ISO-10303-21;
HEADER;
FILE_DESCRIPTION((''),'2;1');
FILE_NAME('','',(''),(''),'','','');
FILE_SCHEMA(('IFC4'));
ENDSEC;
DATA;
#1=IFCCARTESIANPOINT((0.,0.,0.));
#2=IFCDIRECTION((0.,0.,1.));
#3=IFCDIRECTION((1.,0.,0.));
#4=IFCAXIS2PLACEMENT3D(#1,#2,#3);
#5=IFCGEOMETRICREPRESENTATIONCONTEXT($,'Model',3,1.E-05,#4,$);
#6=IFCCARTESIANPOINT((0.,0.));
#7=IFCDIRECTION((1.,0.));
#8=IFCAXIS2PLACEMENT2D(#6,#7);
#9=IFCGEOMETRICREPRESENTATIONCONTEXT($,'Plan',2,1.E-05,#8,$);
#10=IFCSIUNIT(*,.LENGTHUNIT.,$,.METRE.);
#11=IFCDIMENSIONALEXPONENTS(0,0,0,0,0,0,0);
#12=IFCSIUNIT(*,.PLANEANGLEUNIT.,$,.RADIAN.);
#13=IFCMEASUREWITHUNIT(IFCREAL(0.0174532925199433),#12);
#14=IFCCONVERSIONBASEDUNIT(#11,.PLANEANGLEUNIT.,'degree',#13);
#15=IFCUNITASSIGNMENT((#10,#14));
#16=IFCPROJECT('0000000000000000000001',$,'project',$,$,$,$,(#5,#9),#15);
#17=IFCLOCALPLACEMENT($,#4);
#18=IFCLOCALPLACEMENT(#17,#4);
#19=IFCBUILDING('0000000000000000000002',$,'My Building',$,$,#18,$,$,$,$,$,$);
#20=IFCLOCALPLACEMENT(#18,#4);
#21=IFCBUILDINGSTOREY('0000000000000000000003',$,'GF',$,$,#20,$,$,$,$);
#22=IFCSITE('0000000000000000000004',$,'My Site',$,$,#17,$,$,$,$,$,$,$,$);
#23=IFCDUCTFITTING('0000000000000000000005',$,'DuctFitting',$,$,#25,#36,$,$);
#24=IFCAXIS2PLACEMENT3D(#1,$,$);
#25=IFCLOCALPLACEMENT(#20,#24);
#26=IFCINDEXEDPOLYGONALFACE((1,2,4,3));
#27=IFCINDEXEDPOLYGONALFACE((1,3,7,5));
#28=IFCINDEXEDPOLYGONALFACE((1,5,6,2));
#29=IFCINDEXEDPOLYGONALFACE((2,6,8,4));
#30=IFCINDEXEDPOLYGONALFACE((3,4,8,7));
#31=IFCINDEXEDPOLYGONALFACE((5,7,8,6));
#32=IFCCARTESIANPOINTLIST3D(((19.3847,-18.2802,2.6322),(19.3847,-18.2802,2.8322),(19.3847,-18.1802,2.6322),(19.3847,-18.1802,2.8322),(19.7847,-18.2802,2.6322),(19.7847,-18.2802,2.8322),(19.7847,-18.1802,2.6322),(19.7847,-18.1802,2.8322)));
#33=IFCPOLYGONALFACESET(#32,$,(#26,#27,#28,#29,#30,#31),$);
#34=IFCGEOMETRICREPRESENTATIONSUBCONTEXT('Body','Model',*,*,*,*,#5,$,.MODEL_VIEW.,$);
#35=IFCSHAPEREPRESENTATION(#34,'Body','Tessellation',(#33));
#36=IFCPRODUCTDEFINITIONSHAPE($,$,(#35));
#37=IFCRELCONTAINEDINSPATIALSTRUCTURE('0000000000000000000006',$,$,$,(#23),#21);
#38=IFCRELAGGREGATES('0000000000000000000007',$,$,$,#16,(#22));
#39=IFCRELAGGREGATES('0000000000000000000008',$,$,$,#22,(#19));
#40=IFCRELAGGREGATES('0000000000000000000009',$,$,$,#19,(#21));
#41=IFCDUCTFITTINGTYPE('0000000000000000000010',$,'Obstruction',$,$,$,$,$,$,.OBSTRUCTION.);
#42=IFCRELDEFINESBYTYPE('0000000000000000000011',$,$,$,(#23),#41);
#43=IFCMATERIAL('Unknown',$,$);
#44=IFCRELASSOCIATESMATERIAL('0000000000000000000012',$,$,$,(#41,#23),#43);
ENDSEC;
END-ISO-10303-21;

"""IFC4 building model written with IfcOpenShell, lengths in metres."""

from ifc_helpers import new_model, entity, si_unit, converted_unit, frame, origin_with_axes, origin_2d_with_axis, place, context, subcontext, project, spatial, rectangle, extrude, material, material_profile, profile_set, profile_usage, type_object, element, save


model = new_model("IFC4")

# Units and contexts
model_context = context("Model", 3, precision=1e-05, world=origin_with_axes())
plan_context = context("Plan", 2, precision=1e-05, world=origin_2d_with_axis())
body_context_1 = subcontext(model_context, "Body", "Model", "MODEL_VIEW")
ifc_project = project(units=[si_unit("LENGTHUNIT", "METRE"), converted_unit("PLANEANGLEUNIT", "degree", entity("IfcReal", 0.0174532925199433), si_unit("PLANEANGLEUNIT", "RADIAN"), dimensions=[0, 0, 0, 0, 0, 0, 0])], contexts=[model_context, plan_context])

# Site, building, storey
site_placement = place(None, origin_with_axes())
site = spatial("IfcSite", under=ifc_project, at=site_placement, Name="My Site")
building_placement = place(site_placement, origin_with_axes())
building = spatial("IfcBuilding", under=site, at=building_placement, Name="My Building")
storey_placement = place(building_placement, origin_with_axes())
storey = spatial("IfcBuildingStorey", under=building, at=storey_placement, Name="GF")

# Shared definitions
ifc_material = material(Name="Unknown")

# Duct fitting
ifc_material_profile_1 = material_profile(ifc_material, rectangle(XDim=0.4, YDim=0.2))
ifc_profile_set_1 = profile_set([ifc_material_profile_1])
duct_fitting_type_1 = type_object("IfcDuctFittingType", Name="Obstruction", PredefinedType="OBSTRUCTION", material=ifc_profile_set_1)
ifc_profile_usage_1 = profile_usage(ifc_profile_set_1, cardinal=5)
duct_fitting_1_placement = place(storey_placement, frame((19.5847, -18.1802, 2.7322), z_axis=(0.0, -1.0, 0.0), x_axis=(1.0, 0.0, 0.0)))
element("IfcDuctFitting", 1, at=duct_fitting_1_placement, inside=storey, type_object=duct_fitting_type_1, material=ifc_profile_usage_1, Name="DuctFitting", context=body_context_1, shape_type="SweptSolid", body=[
    extrude(rectangle(XDim=0.4, YDim=0.2), origin_with_axes(), (0.0, 0.0, 1.0), 0.1),
])

save(model, "model.ifc")
